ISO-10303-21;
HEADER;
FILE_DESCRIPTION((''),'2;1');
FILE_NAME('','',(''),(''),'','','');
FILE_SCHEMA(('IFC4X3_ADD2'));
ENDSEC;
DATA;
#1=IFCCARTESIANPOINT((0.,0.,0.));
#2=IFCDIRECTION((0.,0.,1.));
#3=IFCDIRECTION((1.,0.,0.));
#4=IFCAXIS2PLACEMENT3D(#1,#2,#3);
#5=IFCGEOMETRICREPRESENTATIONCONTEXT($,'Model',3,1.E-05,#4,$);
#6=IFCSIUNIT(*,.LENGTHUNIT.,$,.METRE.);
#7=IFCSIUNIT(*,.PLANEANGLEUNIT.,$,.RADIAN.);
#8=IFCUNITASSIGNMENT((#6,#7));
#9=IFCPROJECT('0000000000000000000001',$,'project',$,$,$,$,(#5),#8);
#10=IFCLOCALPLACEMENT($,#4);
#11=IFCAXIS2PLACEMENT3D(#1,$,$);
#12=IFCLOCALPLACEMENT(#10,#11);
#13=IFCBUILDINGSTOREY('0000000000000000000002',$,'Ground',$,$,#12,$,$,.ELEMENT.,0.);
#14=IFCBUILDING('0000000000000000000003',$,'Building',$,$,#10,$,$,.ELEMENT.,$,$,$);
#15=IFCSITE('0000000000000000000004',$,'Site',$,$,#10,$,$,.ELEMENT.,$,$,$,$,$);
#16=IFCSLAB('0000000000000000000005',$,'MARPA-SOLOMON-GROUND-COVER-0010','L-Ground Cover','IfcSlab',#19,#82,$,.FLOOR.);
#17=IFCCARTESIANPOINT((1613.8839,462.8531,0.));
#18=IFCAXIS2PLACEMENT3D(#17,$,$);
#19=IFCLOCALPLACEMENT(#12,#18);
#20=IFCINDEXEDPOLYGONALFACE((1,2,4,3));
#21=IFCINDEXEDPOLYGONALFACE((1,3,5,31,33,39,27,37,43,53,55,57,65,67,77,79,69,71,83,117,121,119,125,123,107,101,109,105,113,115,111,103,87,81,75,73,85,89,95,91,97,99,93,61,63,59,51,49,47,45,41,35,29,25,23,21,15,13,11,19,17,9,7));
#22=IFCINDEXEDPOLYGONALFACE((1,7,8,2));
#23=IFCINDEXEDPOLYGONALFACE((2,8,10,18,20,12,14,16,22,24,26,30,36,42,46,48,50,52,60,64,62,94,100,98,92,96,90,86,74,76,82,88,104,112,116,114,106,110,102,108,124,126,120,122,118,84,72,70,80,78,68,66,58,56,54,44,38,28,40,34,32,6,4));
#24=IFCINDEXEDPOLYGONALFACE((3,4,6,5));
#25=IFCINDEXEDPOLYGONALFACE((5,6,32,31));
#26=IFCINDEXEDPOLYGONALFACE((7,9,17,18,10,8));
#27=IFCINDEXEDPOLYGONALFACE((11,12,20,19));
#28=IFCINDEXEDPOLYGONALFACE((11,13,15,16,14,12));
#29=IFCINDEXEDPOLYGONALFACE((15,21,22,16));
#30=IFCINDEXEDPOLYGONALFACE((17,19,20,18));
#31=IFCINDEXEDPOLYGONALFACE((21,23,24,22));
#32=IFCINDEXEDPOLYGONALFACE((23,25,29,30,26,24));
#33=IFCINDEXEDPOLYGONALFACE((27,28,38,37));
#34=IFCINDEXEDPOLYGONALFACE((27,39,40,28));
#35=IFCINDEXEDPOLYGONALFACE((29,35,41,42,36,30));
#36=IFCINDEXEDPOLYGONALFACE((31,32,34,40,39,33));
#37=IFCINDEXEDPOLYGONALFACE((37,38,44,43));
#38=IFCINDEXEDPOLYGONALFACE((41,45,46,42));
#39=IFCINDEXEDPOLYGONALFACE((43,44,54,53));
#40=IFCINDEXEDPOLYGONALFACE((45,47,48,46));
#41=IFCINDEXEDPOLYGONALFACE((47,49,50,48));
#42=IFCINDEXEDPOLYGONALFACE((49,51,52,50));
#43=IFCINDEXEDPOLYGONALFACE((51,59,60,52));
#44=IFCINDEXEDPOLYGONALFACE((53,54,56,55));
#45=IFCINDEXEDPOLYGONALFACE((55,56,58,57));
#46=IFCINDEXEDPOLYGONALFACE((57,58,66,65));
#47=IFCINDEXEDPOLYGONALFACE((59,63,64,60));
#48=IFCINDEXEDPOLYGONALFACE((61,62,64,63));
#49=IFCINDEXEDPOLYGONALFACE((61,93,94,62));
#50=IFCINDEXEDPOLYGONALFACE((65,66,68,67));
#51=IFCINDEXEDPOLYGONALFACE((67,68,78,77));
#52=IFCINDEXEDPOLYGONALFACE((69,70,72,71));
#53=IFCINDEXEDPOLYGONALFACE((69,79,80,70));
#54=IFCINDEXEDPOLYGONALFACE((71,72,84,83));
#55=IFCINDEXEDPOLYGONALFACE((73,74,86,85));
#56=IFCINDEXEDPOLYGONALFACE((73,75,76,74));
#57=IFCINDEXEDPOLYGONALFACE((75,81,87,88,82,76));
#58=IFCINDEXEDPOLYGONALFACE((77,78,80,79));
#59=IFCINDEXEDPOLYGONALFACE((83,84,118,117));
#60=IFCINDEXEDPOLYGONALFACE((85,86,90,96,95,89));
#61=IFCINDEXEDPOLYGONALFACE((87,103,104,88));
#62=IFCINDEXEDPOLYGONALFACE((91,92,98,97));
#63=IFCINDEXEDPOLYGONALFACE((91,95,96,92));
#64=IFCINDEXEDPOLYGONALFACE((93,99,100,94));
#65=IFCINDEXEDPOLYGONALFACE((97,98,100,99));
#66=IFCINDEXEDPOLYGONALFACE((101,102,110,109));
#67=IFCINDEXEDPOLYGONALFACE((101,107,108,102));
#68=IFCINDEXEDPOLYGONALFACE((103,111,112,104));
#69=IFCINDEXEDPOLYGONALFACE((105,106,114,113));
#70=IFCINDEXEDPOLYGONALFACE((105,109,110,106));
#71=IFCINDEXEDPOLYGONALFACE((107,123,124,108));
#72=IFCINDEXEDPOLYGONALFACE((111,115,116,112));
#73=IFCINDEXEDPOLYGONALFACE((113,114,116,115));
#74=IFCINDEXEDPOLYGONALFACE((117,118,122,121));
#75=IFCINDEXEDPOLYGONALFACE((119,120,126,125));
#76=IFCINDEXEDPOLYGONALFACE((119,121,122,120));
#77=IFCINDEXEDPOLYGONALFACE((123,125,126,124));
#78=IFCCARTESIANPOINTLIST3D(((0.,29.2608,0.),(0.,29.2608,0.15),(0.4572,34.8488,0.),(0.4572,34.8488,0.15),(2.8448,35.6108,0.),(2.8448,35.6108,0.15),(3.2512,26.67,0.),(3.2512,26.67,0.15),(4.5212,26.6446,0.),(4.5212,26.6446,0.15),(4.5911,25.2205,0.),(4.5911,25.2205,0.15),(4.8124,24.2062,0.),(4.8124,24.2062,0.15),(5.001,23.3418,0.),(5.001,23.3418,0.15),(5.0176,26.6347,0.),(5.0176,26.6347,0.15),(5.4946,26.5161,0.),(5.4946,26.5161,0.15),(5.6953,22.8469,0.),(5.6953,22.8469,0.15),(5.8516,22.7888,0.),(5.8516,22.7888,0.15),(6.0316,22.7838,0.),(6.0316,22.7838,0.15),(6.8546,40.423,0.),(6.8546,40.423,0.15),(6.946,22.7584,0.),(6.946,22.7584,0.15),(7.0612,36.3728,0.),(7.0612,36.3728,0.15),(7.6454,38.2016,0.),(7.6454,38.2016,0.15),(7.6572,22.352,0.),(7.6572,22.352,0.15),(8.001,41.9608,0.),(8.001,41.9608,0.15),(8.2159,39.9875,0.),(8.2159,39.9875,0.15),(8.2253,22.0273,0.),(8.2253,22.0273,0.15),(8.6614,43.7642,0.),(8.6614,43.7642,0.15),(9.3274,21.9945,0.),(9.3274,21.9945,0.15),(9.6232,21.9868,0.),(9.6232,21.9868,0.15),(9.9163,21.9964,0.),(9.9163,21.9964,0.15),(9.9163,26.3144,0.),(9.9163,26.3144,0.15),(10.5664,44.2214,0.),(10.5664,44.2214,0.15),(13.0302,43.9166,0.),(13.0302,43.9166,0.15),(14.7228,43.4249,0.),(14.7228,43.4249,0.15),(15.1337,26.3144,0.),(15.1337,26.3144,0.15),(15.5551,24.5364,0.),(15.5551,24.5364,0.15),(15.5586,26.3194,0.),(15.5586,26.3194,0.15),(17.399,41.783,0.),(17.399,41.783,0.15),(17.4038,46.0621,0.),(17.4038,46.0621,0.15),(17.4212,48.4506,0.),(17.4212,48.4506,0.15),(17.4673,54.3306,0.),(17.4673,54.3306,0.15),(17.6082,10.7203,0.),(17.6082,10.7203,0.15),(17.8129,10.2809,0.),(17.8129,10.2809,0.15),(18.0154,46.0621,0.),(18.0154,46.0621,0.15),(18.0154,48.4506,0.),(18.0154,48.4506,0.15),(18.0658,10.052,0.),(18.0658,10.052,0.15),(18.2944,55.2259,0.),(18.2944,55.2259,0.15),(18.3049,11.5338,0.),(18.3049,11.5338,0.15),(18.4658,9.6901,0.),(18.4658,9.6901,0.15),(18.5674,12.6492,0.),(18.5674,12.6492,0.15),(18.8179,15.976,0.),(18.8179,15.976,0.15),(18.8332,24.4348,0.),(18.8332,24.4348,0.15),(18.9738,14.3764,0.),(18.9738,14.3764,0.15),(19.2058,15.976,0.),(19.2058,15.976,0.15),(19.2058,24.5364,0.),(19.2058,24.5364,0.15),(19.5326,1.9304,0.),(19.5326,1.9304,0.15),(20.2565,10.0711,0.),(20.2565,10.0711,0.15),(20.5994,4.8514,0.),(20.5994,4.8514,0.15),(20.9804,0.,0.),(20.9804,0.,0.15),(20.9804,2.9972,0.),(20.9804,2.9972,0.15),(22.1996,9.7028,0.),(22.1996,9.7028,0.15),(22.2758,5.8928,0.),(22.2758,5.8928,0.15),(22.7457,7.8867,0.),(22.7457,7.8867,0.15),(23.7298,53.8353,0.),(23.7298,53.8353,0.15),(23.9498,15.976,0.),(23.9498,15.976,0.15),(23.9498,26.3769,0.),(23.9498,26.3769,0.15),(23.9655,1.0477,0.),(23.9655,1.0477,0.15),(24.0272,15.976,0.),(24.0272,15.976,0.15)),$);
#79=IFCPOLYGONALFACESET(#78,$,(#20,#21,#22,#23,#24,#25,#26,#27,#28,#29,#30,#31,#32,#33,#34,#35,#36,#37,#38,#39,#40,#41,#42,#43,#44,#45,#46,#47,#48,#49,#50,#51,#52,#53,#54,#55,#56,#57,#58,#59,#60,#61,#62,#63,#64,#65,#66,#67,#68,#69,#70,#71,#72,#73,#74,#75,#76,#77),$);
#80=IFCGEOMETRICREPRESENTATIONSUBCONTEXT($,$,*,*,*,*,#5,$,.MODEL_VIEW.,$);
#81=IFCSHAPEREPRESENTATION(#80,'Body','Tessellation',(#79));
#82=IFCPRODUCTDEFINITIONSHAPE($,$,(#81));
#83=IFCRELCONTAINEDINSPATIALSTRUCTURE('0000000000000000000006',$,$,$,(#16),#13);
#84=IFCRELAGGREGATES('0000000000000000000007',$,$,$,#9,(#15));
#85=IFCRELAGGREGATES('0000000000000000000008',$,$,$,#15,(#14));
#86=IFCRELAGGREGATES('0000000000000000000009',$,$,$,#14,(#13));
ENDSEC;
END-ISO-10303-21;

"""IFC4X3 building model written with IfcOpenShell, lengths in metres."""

from ifc_helpers import new_model, si_unit, frame, origin, origin_with_axes, place, context, subcontext, project, spatial, polyline, outline, extrude, element, save


model = new_model("IFC4X3")

# Units and contexts
model_context = context("Model", 3, precision=1e-05, world=origin_with_axes())
sub_context = subcontext(model_context, None, None, "MODEL_VIEW")
ifc_project = project(units=[si_unit("LENGTHUNIT", "METRE"), si_unit("PLANEANGLEUNIT", "RADIAN")], contexts=[model_context])

# Site, building, storey
placement = place(None, origin_with_axes())
site = spatial("IfcSite", under=ifc_project, at=placement, Name="Site", CompositionType="ELEMENT")
building = spatial("IfcBuilding", under=site, at=placement, Name="Building", CompositionType="ELEMENT")
storey_placement = place(placement, origin())
storey = spatial("IfcBuildingStorey", under=building, at=storey_placement, Name="Ground", CompositionType="ELEMENT", Elevation=0.0)

# Slab
slab_1_placement = place(storey_placement, frame((1613.8839, 462.8531, 0.0)))
element("IfcSlab", 1, at=slab_1_placement, inside=storey, Name="MARPA-SOLOMON-GROUND-COVER-0010", Description="L-Ground Cover", ObjectType="IfcSlab", PredefinedType="FLOOR", context=sub_context, shape_type="SweptSolid", body=[
    extrude(outline(polyline([(6.8546, 40.423), (8.2159, 39.9875), (7.6454, 38.2016), (7.0612, 36.3728), (2.8448, 35.6108), (0.4572, 34.8488), (0.0, 29.2608), (3.2512, 26.67), (4.5212, 26.6446), (5.0176, 26.6347), (5.4946, 26.5161), (4.5911, 25.2205), (4.8124, 24.2062), (5.001, 23.3418), (5.6953, 22.8469), (5.8516, 22.7888), (6.0316, 22.7838), (6.946, 22.7584), (7.6572, 22.352), (8.2253, 22.0273), (9.3274, 21.9945), (9.6232, 21.9868), (9.9163, 21.9964), (9.9163, 26.3144), (15.1337, 26.3144), (15.5586, 26.3194), (15.5551, 24.5364), (18.8332, 24.4348), (19.2058, 24.5364), (19.2058, 15.976), (18.8179, 15.976), (18.9738, 14.3764), (18.5674, 12.6492), (18.3049, 11.5338), (17.6082, 10.7203), (17.8129, 10.2809), (18.0658, 10.052), (18.4658, 9.6901), (20.2565, 10.0711), (22.1996, 9.7028), (22.7457, 7.8867), (22.2758, 5.8928), (20.5994, 4.8514), (20.9804, 2.9972), (19.5326, 1.9304), (20.9804, 0.0), (23.9655, 1.0477), (24.0272, 15.976), (23.9498, 15.976), (23.9498, 26.3769), (23.7298, 53.8353), (18.2944, 55.2259), (17.4673, 54.3306), (17.4212, 48.4506), (18.0154, 48.4506), (18.0154, 46.0621), (17.4038, 46.0621), (17.399, 41.783), (14.7228, 43.4249), (13.0302, 43.9166), (10.5664, 44.2214), (8.6614, 43.7642), (8.001, 41.9608), (6.8546, 40.423)])), origin(), (0.0, 0.0, 1.0), 0.15),
])

save(model, "model.ifc")
